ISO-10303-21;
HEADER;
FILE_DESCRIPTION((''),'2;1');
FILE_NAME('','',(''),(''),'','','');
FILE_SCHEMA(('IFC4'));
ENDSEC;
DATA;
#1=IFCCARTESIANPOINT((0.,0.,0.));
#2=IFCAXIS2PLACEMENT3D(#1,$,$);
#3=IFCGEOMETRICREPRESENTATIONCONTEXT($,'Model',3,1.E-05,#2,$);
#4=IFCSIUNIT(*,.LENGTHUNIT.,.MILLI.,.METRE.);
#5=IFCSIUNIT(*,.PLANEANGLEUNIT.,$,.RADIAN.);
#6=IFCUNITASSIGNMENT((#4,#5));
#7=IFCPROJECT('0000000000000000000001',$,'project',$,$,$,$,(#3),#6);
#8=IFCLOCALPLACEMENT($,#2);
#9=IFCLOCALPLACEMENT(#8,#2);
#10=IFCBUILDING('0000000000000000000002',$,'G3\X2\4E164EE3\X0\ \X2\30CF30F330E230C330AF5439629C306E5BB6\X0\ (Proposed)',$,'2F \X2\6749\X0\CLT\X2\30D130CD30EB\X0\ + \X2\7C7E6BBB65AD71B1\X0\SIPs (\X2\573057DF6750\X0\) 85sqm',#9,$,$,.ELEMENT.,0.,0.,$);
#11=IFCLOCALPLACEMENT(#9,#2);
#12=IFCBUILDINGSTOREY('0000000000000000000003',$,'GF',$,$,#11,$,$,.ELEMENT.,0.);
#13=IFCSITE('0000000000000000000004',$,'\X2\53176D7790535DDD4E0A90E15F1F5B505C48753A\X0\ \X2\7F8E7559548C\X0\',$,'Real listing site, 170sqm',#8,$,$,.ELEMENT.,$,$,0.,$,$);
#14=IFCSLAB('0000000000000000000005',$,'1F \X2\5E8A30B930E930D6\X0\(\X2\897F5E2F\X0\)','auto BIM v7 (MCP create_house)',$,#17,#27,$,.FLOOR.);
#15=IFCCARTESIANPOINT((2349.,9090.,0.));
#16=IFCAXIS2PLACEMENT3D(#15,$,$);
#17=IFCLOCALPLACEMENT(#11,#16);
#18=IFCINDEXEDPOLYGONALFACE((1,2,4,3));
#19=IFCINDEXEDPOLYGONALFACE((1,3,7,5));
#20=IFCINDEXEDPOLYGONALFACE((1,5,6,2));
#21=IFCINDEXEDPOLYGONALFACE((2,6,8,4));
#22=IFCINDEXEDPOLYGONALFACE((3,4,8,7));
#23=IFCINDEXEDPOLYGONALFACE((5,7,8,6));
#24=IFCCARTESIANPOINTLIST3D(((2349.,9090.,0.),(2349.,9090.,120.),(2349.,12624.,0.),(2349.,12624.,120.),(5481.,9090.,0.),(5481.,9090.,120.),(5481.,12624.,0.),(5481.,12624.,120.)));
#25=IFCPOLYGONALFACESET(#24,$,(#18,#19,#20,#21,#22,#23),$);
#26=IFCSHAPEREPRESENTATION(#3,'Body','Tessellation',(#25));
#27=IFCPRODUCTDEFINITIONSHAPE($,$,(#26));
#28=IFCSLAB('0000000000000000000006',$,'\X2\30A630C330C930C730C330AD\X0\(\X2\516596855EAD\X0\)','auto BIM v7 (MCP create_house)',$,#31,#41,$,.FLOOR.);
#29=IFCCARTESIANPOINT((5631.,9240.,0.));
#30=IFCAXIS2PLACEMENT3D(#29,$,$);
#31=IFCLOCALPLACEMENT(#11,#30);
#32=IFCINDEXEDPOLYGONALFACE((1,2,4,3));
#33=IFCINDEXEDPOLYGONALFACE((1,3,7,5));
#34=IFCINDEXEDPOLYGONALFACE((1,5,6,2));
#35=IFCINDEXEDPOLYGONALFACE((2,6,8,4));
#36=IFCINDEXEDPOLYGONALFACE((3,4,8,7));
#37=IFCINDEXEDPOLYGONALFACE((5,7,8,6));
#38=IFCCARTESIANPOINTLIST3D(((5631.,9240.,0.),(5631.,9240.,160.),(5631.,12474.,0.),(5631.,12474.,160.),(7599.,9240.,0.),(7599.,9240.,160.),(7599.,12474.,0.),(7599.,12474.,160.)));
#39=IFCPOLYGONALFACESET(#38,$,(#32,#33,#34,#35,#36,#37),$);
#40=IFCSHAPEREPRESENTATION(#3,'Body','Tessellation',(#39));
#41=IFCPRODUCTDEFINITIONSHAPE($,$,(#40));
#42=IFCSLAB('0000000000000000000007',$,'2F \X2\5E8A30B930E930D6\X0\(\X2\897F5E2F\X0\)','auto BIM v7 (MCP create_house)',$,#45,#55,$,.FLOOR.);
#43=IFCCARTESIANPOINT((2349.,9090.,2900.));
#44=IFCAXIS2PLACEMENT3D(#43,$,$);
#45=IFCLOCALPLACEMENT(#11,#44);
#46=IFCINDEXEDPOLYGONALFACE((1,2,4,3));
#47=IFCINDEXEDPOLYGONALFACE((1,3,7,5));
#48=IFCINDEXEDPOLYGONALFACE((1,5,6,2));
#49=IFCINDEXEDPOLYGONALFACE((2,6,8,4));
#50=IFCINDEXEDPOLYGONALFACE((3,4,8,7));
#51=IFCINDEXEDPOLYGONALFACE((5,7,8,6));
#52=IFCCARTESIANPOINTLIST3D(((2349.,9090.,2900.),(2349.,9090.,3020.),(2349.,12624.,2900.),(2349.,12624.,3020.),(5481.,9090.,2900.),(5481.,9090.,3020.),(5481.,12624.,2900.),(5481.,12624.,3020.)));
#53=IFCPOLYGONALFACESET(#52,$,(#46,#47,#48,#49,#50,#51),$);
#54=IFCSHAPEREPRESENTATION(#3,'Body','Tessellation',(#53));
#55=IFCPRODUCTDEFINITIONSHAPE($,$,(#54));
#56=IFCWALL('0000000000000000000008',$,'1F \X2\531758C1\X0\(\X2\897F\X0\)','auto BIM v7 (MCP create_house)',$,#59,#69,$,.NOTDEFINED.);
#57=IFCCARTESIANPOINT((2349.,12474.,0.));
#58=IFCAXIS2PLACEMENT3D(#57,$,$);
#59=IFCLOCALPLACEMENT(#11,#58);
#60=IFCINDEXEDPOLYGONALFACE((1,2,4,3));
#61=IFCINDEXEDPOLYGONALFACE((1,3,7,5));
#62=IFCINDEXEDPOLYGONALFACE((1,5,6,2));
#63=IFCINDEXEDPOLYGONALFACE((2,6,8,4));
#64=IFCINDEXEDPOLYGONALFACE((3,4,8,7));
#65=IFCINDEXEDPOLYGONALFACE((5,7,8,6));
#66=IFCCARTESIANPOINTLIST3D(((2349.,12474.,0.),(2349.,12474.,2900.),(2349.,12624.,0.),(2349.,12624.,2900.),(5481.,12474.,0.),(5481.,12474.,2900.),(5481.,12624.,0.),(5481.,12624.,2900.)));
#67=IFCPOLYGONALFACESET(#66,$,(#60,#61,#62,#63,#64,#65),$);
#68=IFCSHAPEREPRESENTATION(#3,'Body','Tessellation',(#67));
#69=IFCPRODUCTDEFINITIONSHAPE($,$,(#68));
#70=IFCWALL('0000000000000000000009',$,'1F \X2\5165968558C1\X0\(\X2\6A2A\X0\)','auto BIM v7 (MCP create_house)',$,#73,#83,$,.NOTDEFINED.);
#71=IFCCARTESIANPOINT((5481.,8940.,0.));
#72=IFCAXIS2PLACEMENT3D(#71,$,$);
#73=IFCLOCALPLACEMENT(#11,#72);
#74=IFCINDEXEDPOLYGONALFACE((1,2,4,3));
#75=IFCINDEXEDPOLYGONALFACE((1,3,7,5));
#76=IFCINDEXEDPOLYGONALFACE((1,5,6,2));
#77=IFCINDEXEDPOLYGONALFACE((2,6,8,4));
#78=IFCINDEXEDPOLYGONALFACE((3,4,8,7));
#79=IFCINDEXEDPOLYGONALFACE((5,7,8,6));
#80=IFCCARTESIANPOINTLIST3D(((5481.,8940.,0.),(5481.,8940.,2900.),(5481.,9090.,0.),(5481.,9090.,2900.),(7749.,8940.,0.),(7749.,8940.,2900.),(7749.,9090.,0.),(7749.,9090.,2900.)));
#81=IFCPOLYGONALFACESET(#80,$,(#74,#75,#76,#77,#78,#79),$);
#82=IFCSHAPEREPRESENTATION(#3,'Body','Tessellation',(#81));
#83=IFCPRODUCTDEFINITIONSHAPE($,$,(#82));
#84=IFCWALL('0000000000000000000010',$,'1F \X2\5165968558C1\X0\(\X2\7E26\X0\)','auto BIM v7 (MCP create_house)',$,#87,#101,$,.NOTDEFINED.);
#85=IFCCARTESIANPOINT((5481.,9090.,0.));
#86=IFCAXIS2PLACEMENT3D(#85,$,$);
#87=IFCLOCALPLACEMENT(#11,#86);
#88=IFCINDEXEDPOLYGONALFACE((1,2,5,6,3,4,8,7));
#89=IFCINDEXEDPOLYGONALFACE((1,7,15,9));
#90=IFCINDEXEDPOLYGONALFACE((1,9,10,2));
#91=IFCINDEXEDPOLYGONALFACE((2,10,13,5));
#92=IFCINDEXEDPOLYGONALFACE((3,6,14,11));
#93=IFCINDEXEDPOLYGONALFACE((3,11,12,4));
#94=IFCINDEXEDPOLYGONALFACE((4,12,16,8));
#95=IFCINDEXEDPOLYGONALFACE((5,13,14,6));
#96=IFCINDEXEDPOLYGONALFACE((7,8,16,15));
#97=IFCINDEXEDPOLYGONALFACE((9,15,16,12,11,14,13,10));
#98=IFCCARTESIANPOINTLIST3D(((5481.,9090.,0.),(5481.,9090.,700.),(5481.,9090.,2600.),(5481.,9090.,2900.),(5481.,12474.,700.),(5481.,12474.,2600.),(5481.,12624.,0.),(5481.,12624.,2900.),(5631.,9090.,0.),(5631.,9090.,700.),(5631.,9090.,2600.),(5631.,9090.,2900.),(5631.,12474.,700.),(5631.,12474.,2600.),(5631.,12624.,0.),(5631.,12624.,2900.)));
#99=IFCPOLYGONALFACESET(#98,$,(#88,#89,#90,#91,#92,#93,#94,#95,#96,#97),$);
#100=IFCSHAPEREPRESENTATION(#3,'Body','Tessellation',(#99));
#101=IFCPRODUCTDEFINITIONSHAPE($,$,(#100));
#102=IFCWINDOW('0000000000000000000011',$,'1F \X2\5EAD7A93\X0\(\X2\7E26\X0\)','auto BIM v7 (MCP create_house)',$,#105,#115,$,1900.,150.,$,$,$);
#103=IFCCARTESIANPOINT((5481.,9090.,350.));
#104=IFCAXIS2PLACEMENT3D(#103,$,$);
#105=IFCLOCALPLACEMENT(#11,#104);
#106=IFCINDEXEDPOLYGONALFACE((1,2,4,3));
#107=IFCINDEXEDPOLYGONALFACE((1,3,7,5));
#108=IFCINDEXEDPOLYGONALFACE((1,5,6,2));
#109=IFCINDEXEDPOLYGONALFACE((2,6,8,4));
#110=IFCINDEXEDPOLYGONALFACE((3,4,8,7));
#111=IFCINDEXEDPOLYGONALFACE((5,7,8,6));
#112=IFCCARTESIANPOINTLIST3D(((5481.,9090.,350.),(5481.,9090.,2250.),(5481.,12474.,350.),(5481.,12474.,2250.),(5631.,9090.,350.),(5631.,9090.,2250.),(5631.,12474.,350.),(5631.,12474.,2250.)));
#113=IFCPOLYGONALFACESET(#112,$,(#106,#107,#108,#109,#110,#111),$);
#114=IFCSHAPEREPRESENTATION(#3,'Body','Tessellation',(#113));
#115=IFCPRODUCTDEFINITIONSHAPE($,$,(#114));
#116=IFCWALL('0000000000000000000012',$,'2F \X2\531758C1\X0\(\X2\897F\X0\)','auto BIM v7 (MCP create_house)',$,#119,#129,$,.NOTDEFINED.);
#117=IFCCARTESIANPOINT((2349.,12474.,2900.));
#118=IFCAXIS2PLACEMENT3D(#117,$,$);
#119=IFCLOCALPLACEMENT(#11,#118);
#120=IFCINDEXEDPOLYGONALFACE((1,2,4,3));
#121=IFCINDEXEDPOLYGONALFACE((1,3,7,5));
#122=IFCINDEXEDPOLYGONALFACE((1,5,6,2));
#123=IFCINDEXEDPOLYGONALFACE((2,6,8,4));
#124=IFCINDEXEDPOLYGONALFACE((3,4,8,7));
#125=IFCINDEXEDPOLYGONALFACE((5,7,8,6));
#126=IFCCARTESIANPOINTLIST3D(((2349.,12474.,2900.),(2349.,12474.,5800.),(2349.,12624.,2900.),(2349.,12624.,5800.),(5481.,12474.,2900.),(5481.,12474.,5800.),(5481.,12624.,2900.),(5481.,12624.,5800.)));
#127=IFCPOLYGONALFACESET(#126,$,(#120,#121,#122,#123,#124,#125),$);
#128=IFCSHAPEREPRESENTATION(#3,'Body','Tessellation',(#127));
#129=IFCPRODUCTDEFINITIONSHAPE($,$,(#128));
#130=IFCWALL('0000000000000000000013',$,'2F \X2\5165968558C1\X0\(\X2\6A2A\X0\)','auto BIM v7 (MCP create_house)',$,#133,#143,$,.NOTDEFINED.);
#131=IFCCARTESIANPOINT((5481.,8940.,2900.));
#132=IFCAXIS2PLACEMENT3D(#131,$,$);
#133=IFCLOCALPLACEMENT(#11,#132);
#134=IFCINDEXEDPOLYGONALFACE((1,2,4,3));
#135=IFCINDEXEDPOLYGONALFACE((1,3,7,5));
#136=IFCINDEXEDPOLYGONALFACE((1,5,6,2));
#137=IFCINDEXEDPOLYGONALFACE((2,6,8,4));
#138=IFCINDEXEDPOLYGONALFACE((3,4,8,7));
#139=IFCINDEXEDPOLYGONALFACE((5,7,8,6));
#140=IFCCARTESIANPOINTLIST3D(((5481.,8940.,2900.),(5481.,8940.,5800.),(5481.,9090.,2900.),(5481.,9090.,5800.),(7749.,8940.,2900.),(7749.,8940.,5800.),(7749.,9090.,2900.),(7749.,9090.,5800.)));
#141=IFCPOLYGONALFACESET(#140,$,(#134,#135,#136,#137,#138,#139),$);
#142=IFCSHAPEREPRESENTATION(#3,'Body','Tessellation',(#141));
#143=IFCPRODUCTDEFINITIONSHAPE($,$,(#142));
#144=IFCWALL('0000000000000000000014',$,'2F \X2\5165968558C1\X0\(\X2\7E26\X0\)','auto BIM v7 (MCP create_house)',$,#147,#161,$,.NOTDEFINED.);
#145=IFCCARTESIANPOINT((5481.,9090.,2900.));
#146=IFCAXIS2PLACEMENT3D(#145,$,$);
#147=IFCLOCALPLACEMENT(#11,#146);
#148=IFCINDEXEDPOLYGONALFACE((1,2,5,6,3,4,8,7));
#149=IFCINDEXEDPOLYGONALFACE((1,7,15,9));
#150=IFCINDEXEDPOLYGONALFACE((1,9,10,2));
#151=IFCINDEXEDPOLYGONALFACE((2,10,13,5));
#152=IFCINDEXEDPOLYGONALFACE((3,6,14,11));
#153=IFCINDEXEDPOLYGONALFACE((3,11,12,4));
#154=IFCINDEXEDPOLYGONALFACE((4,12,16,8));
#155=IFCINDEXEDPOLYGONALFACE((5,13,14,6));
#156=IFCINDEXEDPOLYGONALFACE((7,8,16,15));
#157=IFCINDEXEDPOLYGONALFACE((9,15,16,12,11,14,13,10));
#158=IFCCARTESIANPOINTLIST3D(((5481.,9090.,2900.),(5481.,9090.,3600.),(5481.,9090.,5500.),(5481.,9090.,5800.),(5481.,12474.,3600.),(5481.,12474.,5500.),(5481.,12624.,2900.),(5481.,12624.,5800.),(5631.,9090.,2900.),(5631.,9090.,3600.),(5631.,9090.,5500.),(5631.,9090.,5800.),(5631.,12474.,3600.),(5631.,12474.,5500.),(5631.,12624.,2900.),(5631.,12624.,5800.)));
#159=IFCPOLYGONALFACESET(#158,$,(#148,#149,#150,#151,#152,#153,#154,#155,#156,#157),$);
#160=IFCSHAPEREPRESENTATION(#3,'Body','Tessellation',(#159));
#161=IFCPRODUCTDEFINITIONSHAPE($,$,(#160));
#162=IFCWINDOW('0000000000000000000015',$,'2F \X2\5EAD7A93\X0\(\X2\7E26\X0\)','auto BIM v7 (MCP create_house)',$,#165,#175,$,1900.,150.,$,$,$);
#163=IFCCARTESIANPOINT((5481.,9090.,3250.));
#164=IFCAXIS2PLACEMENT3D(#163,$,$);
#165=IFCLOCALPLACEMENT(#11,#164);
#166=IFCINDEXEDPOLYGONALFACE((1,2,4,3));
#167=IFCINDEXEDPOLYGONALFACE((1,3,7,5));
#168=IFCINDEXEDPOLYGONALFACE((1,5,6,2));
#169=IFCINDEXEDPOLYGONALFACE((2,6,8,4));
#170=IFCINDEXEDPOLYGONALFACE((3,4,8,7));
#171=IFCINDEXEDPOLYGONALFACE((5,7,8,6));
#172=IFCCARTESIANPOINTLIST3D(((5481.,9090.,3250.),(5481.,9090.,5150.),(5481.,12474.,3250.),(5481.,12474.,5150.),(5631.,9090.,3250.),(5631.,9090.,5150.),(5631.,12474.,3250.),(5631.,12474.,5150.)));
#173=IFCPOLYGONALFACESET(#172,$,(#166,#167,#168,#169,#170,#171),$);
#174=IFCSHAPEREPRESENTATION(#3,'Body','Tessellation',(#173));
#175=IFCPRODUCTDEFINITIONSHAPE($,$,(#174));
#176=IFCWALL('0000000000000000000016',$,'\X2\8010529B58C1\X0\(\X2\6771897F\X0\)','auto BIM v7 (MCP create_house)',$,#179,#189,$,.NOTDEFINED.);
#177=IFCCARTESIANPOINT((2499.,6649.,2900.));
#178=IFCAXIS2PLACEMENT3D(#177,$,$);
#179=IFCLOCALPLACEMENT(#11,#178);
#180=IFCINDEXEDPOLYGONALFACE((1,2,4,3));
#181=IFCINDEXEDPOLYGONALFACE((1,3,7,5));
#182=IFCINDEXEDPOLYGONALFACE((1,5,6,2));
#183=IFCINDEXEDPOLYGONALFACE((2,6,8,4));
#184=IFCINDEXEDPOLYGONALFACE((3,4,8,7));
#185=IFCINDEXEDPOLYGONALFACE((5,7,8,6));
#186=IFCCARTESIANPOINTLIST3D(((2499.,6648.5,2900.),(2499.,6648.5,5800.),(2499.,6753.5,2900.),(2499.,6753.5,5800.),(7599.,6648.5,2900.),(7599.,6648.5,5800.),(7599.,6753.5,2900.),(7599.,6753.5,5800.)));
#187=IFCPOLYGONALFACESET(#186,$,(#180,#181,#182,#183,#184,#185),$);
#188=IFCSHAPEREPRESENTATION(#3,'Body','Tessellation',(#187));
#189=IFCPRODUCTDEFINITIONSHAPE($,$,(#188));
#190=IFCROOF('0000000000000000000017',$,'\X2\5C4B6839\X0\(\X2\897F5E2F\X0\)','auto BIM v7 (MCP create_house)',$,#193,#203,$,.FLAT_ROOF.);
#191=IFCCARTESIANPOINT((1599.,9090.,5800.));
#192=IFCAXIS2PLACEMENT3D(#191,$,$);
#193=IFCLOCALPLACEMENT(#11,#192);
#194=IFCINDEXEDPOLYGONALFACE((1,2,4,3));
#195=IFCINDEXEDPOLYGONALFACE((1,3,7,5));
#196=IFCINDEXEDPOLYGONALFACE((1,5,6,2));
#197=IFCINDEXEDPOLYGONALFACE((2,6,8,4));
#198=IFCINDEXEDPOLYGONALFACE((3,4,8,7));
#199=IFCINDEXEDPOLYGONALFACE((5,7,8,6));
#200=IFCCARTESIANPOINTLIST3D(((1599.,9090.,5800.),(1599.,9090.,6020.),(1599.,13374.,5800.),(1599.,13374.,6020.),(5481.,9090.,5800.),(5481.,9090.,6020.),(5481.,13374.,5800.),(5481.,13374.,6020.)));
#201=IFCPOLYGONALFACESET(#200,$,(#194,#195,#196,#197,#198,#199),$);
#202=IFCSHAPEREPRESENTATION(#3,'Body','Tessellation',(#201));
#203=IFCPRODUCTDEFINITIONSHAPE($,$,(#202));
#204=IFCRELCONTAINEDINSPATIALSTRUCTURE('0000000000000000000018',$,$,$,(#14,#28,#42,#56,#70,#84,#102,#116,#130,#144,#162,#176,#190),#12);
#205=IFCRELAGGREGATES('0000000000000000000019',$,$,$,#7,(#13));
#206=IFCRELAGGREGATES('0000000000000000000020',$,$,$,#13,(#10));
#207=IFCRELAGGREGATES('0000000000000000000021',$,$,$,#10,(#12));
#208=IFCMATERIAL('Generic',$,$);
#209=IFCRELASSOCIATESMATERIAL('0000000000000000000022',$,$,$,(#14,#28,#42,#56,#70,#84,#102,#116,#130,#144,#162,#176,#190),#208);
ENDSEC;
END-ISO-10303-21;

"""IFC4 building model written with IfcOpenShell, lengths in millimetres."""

from ifc_helpers import new_model, si_unit, frame, frame_2d, origin, place, context, project, spatial, rectangle, extrude, material, element, fill, save


model = new_model("IFC4")

# Units and contexts
model_context = context("Model", 3, precision=1e-05, world=origin())
ifc_project = project(units=[si_unit("LENGTHUNIT", "METRE", prefix="MILLI"), si_unit("PLANEANGLEUNIT", "RADIAN")], contexts=[model_context])

# Site, building, storey
site_placement = place(None, origin())
site = spatial("IfcSite", under=ifc_project, at=site_placement, Name="北海道川上郡弟子屈町 美留和", ObjectType="Real listing site, 170sqm", CompositionType="ELEMENT", RefElevation=0.0)
building_placement = place(site_placement, origin())
building = spatial("IfcBuilding", under=site, at=building_placement, Name="G3世代 ハンモック吹抜の家 (Proposed)", ObjectType="2F 杉CLTパネル + 籾殻断熱SIPs (地域材) 85sqm", CompositionType="ELEMENT", ElevationOfRefHeight=0.0, ElevationOfTerrain=0.0)
storey_placement = place(building_placement, origin())
storey = spatial("IfcBuildingStorey", under=building, at=storey_placement, Name="GF", CompositionType="ELEMENT", Elevation=0.0)

# Slabs
ifc_material = material(Name="Generic")
slab_1_placement = place(storey_placement, frame((2349.0, 9090.0, 0.0)))
element("IfcSlab", 1, at=slab_1_placement, inside=storey, material=ifc_material, Name="1F 床スラブ(西帯)", Description="auto BIM v7 (MCP create_house)", PredefinedType="FLOOR", context=model_context, shape_type="SweptSolid", body=[
    extrude(rectangle(XDim=3132.0, YDim=3534.0, at=frame_2d((1566.0, 1767.0))), frame((2349.0, 9090.0, 0.0)), (0.0, 0.0, 1.0), 120.0),
])
slab_2_placement = place(storey_placement, frame((5631.0, 9240.0, 0.0)))
element("IfcSlab", 2, at=slab_2_placement, inside=storey, material=ifc_material, Name="ウッドデッキ(入隅庭)", Description="auto BIM v7 (MCP create_house)", PredefinedType="FLOOR", context=model_context, shape_type="SweptSolid", body=[
    extrude(rectangle(XDim=1968.0, YDim=3234.0, at=frame_2d((984.0, 1617.0))), frame((5631.0, 9240.0, 0.0)), (0.0, 0.0, 1.0), 160.0),
])
slab_3_placement = place(storey_placement, frame((2349.0, 9090.0, 2900.0)))
element("IfcSlab", 3, at=slab_3_placement, inside=storey, material=ifc_material, Name="2F 床スラブ(西帯)", Description="auto BIM v7 (MCP create_house)", PredefinedType="FLOOR", context=model_context, shape_type="SweptSolid", body=[
    extrude(rectangle(XDim=3132.0, YDim=3534.0, at=frame_2d((1566.0, 1767.0))), frame((2349.0, 9090.0, 2900.0)), (0.0, 0.0, 1.0), 120.0),
])

# Walls
wall_1_placement = place(storey_placement, frame((2349.0, 12474.0, 0.0)))
element("IfcWall", 4, at=wall_1_placement, inside=storey, material=ifc_material, Name="1F 北壁(西)", Description="auto BIM v7 (MCP create_house)", PredefinedType="NOTDEFINED", context=model_context, shape_type="SweptSolid", body=[
    extrude(rectangle(XDim=3132.0, YDim=150.0, at=frame_2d((1566.0, 75.0))), frame((2349.0, 12474.0, 0.0)), (0.0, 0.0, 1.0), 2900.0),
])
wall_2_placement = place(storey_placement, frame((5481.0, 8940.0, 0.0)))
element("IfcWall", 5, at=wall_2_placement, inside=storey, material=ifc_material, Name="1F 入隅壁(横)", Description="auto BIM v7 (MCP create_house)", PredefinedType="NOTDEFINED", context=model_context, shape_type="SweptSolid", body=[
    extrude(rectangle(XDim=2268.0, YDim=150.0, at=frame_2d((1134.0, 75.0))), frame((5481.0, 8940.0, 0.0)), (0.0, 0.0, 1.0), 2900.0),
])

# Wall, opening, window
wall_3_placement = place(storey_placement, frame((5481.0, 9090.0, 0.0)))
wall_3 = element("IfcWall", 6, at=wall_3_placement, inside=storey, material=ifc_material, Name="1F 入隅壁(縦)", Description="auto BIM v7 (MCP create_house)", PredefinedType="NOTDEFINED", context=model_context, shape_type="SweptSolid", body=[
    extrude(rectangle(XDim=150.0, YDim=3534.0, at=frame_2d((75.0, 1767.0))), frame((5481.0, 9090.0, 0.0)), (0.0, 0.0, 1.0), 2900.0),
])
opening_1_placement = place(storey_placement, frame((5481.0, 9090.0, 350.0)))
opening_1 = element("IfcOpeningElement", 7, at=opening_1_placement, cuts=wall_3, PredefinedType="NOTDEFINED", context=model_context, shape_type="SweptSolid", body=[
    extrude(rectangle(XDim=150.0, YDim=3384.0, at=frame_2d((75.0, 1692.0))), frame((5481.0, 9090.0, 350.0)), (0.0, 0.0, 1.0), 1900.0),
])
window_1_placement = place(storey_placement, frame((5481.0, 9090.0, 350.0)))
window_1 = element("IfcWindow", 8, at=window_1_placement, inside=storey, material=ifc_material, Name="1F 庭窓(縦)", Description="auto BIM v7 (MCP create_house)", OverallHeight=1900.0, OverallWidth=150.0, context=model_context, shape_type="SweptSolid", body=[
    extrude(rectangle(XDim=150.0, YDim=3384.0, at=frame_2d((75.0, 1692.0))), frame((5481.0, 9090.0, 350.0)), (0.0, 0.0, 1.0), 1900.0),
])
fill(opening_1, window_1)

# Walls
wall_4_placement = place(storey_placement, frame((2349.0, 12474.0, 2900.0)))
element("IfcWall", 9, at=wall_4_placement, inside=storey, material=ifc_material, Name="2F 北壁(西)", Description="auto BIM v7 (MCP create_house)", PredefinedType="NOTDEFINED", context=model_context, shape_type="SweptSolid", body=[
    extrude(rectangle(XDim=3132.0, YDim=150.0, at=frame_2d((1566.0, 75.0))), frame((2349.0, 12474.0, 2900.0)), (0.0, 0.0, 1.0), 2900.0),
])
wall_5_placement = place(storey_placement, frame((5481.0, 8940.0, 2900.0)))
element("IfcWall", 10, at=wall_5_placement, inside=storey, material=ifc_material, Name="2F 入隅壁(横)", Description="auto BIM v7 (MCP create_house)", PredefinedType="NOTDEFINED", context=model_context, shape_type="SweptSolid", body=[
    extrude(rectangle(XDim=2268.0, YDim=150.0, at=frame_2d((1134.0, 75.0))), frame((5481.0, 8940.0, 2900.0)), (0.0, 0.0, 1.0), 2900.0),
])

# Wall, opening, window
wall_6_placement = place(storey_placement, frame((5481.0, 9090.0, 2900.0)))
wall_6 = element("IfcWall", 11, at=wall_6_placement, inside=storey, material=ifc_material, Name="2F 入隅壁(縦)", Description="auto BIM v7 (MCP create_house)", PredefinedType="NOTDEFINED", context=model_context, shape_type="SweptSolid", body=[
    extrude(rectangle(XDim=150.0, YDim=3534.0, at=frame_2d((75.0, 1767.0))), frame((5481.0, 9090.0, 2900.0)), (0.0, 0.0, 1.0), 2900.0),
])
opening_2_placement = place(storey_placement, frame((5481.0, 9090.0, 3250.0)))
opening_2 = element("IfcOpeningElement", 12, at=opening_2_placement, cuts=wall_6, PredefinedType="NOTDEFINED", context=model_context, shape_type="SweptSolid", body=[
    extrude(rectangle(XDim=150.0, YDim=3384.0, at=frame_2d((75.0, 1692.0))), frame((5481.0, 9090.0, 3250.0)), (0.0, 0.0, 1.0), 1900.0),
])
window_2_placement = place(storey_placement, frame((5481.0, 9090.0, 3250.0)))
window_2 = element("IfcWindow", 13, at=window_2_placement, inside=storey, material=ifc_material, Name="2F 庭窓(縦)", Description="auto BIM v7 (MCP create_house)", OverallHeight=1900.0, OverallWidth=150.0, context=model_context, shape_type="SweptSolid", body=[
    extrude(rectangle(XDim=150.0, YDim=3384.0, at=frame_2d((75.0, 1692.0))), frame((5481.0, 9090.0, 3250.0)), (0.0, 0.0, 1.0), 1900.0),
])
fill(opening_2, window_2)

# Wall
wall_7_placement = place(storey_placement, frame((2499.0, 6649.0, 2900.0)))
element("IfcWall", 14, at=wall_7_placement, inside=storey, material=ifc_material, Name="耐力壁(東西)", Description="auto BIM v7 (MCP create_house)", PredefinedType="NOTDEFINED", context=model_context, shape_type="SweptSolid", body=[
    extrude(rectangle(XDim=5100.0, YDim=105.0, at=frame_2d((2550.0, 52.0))), frame((2499.0, 6649.0, 2900.0)), (0.0, 0.0, 1.0), 2900.0),
])

# Roof
for number, where, name in (
    (15, (1599.0, 9090.0, 5800.0), "屋根(西帯)"),
):
    element("IfcRoof", number, at=place(storey_placement, frame(where)), inside=storey, material=ifc_material, Name=name, Description="auto BIM v7 (MCP create_house)", PredefinedType="FLAT_ROOF", context=model_context, shape_type="SweptSolid", body=[
        extrude(rectangle(XDim=3882.0, YDim=4284.0, at=frame_2d((1941.0, 2142.0))), frame((1599.0, 9090.0, 5800.0)), (0.0, 0.0, 1.0), 220.0),
    ])

save(model, "model.ifc")
